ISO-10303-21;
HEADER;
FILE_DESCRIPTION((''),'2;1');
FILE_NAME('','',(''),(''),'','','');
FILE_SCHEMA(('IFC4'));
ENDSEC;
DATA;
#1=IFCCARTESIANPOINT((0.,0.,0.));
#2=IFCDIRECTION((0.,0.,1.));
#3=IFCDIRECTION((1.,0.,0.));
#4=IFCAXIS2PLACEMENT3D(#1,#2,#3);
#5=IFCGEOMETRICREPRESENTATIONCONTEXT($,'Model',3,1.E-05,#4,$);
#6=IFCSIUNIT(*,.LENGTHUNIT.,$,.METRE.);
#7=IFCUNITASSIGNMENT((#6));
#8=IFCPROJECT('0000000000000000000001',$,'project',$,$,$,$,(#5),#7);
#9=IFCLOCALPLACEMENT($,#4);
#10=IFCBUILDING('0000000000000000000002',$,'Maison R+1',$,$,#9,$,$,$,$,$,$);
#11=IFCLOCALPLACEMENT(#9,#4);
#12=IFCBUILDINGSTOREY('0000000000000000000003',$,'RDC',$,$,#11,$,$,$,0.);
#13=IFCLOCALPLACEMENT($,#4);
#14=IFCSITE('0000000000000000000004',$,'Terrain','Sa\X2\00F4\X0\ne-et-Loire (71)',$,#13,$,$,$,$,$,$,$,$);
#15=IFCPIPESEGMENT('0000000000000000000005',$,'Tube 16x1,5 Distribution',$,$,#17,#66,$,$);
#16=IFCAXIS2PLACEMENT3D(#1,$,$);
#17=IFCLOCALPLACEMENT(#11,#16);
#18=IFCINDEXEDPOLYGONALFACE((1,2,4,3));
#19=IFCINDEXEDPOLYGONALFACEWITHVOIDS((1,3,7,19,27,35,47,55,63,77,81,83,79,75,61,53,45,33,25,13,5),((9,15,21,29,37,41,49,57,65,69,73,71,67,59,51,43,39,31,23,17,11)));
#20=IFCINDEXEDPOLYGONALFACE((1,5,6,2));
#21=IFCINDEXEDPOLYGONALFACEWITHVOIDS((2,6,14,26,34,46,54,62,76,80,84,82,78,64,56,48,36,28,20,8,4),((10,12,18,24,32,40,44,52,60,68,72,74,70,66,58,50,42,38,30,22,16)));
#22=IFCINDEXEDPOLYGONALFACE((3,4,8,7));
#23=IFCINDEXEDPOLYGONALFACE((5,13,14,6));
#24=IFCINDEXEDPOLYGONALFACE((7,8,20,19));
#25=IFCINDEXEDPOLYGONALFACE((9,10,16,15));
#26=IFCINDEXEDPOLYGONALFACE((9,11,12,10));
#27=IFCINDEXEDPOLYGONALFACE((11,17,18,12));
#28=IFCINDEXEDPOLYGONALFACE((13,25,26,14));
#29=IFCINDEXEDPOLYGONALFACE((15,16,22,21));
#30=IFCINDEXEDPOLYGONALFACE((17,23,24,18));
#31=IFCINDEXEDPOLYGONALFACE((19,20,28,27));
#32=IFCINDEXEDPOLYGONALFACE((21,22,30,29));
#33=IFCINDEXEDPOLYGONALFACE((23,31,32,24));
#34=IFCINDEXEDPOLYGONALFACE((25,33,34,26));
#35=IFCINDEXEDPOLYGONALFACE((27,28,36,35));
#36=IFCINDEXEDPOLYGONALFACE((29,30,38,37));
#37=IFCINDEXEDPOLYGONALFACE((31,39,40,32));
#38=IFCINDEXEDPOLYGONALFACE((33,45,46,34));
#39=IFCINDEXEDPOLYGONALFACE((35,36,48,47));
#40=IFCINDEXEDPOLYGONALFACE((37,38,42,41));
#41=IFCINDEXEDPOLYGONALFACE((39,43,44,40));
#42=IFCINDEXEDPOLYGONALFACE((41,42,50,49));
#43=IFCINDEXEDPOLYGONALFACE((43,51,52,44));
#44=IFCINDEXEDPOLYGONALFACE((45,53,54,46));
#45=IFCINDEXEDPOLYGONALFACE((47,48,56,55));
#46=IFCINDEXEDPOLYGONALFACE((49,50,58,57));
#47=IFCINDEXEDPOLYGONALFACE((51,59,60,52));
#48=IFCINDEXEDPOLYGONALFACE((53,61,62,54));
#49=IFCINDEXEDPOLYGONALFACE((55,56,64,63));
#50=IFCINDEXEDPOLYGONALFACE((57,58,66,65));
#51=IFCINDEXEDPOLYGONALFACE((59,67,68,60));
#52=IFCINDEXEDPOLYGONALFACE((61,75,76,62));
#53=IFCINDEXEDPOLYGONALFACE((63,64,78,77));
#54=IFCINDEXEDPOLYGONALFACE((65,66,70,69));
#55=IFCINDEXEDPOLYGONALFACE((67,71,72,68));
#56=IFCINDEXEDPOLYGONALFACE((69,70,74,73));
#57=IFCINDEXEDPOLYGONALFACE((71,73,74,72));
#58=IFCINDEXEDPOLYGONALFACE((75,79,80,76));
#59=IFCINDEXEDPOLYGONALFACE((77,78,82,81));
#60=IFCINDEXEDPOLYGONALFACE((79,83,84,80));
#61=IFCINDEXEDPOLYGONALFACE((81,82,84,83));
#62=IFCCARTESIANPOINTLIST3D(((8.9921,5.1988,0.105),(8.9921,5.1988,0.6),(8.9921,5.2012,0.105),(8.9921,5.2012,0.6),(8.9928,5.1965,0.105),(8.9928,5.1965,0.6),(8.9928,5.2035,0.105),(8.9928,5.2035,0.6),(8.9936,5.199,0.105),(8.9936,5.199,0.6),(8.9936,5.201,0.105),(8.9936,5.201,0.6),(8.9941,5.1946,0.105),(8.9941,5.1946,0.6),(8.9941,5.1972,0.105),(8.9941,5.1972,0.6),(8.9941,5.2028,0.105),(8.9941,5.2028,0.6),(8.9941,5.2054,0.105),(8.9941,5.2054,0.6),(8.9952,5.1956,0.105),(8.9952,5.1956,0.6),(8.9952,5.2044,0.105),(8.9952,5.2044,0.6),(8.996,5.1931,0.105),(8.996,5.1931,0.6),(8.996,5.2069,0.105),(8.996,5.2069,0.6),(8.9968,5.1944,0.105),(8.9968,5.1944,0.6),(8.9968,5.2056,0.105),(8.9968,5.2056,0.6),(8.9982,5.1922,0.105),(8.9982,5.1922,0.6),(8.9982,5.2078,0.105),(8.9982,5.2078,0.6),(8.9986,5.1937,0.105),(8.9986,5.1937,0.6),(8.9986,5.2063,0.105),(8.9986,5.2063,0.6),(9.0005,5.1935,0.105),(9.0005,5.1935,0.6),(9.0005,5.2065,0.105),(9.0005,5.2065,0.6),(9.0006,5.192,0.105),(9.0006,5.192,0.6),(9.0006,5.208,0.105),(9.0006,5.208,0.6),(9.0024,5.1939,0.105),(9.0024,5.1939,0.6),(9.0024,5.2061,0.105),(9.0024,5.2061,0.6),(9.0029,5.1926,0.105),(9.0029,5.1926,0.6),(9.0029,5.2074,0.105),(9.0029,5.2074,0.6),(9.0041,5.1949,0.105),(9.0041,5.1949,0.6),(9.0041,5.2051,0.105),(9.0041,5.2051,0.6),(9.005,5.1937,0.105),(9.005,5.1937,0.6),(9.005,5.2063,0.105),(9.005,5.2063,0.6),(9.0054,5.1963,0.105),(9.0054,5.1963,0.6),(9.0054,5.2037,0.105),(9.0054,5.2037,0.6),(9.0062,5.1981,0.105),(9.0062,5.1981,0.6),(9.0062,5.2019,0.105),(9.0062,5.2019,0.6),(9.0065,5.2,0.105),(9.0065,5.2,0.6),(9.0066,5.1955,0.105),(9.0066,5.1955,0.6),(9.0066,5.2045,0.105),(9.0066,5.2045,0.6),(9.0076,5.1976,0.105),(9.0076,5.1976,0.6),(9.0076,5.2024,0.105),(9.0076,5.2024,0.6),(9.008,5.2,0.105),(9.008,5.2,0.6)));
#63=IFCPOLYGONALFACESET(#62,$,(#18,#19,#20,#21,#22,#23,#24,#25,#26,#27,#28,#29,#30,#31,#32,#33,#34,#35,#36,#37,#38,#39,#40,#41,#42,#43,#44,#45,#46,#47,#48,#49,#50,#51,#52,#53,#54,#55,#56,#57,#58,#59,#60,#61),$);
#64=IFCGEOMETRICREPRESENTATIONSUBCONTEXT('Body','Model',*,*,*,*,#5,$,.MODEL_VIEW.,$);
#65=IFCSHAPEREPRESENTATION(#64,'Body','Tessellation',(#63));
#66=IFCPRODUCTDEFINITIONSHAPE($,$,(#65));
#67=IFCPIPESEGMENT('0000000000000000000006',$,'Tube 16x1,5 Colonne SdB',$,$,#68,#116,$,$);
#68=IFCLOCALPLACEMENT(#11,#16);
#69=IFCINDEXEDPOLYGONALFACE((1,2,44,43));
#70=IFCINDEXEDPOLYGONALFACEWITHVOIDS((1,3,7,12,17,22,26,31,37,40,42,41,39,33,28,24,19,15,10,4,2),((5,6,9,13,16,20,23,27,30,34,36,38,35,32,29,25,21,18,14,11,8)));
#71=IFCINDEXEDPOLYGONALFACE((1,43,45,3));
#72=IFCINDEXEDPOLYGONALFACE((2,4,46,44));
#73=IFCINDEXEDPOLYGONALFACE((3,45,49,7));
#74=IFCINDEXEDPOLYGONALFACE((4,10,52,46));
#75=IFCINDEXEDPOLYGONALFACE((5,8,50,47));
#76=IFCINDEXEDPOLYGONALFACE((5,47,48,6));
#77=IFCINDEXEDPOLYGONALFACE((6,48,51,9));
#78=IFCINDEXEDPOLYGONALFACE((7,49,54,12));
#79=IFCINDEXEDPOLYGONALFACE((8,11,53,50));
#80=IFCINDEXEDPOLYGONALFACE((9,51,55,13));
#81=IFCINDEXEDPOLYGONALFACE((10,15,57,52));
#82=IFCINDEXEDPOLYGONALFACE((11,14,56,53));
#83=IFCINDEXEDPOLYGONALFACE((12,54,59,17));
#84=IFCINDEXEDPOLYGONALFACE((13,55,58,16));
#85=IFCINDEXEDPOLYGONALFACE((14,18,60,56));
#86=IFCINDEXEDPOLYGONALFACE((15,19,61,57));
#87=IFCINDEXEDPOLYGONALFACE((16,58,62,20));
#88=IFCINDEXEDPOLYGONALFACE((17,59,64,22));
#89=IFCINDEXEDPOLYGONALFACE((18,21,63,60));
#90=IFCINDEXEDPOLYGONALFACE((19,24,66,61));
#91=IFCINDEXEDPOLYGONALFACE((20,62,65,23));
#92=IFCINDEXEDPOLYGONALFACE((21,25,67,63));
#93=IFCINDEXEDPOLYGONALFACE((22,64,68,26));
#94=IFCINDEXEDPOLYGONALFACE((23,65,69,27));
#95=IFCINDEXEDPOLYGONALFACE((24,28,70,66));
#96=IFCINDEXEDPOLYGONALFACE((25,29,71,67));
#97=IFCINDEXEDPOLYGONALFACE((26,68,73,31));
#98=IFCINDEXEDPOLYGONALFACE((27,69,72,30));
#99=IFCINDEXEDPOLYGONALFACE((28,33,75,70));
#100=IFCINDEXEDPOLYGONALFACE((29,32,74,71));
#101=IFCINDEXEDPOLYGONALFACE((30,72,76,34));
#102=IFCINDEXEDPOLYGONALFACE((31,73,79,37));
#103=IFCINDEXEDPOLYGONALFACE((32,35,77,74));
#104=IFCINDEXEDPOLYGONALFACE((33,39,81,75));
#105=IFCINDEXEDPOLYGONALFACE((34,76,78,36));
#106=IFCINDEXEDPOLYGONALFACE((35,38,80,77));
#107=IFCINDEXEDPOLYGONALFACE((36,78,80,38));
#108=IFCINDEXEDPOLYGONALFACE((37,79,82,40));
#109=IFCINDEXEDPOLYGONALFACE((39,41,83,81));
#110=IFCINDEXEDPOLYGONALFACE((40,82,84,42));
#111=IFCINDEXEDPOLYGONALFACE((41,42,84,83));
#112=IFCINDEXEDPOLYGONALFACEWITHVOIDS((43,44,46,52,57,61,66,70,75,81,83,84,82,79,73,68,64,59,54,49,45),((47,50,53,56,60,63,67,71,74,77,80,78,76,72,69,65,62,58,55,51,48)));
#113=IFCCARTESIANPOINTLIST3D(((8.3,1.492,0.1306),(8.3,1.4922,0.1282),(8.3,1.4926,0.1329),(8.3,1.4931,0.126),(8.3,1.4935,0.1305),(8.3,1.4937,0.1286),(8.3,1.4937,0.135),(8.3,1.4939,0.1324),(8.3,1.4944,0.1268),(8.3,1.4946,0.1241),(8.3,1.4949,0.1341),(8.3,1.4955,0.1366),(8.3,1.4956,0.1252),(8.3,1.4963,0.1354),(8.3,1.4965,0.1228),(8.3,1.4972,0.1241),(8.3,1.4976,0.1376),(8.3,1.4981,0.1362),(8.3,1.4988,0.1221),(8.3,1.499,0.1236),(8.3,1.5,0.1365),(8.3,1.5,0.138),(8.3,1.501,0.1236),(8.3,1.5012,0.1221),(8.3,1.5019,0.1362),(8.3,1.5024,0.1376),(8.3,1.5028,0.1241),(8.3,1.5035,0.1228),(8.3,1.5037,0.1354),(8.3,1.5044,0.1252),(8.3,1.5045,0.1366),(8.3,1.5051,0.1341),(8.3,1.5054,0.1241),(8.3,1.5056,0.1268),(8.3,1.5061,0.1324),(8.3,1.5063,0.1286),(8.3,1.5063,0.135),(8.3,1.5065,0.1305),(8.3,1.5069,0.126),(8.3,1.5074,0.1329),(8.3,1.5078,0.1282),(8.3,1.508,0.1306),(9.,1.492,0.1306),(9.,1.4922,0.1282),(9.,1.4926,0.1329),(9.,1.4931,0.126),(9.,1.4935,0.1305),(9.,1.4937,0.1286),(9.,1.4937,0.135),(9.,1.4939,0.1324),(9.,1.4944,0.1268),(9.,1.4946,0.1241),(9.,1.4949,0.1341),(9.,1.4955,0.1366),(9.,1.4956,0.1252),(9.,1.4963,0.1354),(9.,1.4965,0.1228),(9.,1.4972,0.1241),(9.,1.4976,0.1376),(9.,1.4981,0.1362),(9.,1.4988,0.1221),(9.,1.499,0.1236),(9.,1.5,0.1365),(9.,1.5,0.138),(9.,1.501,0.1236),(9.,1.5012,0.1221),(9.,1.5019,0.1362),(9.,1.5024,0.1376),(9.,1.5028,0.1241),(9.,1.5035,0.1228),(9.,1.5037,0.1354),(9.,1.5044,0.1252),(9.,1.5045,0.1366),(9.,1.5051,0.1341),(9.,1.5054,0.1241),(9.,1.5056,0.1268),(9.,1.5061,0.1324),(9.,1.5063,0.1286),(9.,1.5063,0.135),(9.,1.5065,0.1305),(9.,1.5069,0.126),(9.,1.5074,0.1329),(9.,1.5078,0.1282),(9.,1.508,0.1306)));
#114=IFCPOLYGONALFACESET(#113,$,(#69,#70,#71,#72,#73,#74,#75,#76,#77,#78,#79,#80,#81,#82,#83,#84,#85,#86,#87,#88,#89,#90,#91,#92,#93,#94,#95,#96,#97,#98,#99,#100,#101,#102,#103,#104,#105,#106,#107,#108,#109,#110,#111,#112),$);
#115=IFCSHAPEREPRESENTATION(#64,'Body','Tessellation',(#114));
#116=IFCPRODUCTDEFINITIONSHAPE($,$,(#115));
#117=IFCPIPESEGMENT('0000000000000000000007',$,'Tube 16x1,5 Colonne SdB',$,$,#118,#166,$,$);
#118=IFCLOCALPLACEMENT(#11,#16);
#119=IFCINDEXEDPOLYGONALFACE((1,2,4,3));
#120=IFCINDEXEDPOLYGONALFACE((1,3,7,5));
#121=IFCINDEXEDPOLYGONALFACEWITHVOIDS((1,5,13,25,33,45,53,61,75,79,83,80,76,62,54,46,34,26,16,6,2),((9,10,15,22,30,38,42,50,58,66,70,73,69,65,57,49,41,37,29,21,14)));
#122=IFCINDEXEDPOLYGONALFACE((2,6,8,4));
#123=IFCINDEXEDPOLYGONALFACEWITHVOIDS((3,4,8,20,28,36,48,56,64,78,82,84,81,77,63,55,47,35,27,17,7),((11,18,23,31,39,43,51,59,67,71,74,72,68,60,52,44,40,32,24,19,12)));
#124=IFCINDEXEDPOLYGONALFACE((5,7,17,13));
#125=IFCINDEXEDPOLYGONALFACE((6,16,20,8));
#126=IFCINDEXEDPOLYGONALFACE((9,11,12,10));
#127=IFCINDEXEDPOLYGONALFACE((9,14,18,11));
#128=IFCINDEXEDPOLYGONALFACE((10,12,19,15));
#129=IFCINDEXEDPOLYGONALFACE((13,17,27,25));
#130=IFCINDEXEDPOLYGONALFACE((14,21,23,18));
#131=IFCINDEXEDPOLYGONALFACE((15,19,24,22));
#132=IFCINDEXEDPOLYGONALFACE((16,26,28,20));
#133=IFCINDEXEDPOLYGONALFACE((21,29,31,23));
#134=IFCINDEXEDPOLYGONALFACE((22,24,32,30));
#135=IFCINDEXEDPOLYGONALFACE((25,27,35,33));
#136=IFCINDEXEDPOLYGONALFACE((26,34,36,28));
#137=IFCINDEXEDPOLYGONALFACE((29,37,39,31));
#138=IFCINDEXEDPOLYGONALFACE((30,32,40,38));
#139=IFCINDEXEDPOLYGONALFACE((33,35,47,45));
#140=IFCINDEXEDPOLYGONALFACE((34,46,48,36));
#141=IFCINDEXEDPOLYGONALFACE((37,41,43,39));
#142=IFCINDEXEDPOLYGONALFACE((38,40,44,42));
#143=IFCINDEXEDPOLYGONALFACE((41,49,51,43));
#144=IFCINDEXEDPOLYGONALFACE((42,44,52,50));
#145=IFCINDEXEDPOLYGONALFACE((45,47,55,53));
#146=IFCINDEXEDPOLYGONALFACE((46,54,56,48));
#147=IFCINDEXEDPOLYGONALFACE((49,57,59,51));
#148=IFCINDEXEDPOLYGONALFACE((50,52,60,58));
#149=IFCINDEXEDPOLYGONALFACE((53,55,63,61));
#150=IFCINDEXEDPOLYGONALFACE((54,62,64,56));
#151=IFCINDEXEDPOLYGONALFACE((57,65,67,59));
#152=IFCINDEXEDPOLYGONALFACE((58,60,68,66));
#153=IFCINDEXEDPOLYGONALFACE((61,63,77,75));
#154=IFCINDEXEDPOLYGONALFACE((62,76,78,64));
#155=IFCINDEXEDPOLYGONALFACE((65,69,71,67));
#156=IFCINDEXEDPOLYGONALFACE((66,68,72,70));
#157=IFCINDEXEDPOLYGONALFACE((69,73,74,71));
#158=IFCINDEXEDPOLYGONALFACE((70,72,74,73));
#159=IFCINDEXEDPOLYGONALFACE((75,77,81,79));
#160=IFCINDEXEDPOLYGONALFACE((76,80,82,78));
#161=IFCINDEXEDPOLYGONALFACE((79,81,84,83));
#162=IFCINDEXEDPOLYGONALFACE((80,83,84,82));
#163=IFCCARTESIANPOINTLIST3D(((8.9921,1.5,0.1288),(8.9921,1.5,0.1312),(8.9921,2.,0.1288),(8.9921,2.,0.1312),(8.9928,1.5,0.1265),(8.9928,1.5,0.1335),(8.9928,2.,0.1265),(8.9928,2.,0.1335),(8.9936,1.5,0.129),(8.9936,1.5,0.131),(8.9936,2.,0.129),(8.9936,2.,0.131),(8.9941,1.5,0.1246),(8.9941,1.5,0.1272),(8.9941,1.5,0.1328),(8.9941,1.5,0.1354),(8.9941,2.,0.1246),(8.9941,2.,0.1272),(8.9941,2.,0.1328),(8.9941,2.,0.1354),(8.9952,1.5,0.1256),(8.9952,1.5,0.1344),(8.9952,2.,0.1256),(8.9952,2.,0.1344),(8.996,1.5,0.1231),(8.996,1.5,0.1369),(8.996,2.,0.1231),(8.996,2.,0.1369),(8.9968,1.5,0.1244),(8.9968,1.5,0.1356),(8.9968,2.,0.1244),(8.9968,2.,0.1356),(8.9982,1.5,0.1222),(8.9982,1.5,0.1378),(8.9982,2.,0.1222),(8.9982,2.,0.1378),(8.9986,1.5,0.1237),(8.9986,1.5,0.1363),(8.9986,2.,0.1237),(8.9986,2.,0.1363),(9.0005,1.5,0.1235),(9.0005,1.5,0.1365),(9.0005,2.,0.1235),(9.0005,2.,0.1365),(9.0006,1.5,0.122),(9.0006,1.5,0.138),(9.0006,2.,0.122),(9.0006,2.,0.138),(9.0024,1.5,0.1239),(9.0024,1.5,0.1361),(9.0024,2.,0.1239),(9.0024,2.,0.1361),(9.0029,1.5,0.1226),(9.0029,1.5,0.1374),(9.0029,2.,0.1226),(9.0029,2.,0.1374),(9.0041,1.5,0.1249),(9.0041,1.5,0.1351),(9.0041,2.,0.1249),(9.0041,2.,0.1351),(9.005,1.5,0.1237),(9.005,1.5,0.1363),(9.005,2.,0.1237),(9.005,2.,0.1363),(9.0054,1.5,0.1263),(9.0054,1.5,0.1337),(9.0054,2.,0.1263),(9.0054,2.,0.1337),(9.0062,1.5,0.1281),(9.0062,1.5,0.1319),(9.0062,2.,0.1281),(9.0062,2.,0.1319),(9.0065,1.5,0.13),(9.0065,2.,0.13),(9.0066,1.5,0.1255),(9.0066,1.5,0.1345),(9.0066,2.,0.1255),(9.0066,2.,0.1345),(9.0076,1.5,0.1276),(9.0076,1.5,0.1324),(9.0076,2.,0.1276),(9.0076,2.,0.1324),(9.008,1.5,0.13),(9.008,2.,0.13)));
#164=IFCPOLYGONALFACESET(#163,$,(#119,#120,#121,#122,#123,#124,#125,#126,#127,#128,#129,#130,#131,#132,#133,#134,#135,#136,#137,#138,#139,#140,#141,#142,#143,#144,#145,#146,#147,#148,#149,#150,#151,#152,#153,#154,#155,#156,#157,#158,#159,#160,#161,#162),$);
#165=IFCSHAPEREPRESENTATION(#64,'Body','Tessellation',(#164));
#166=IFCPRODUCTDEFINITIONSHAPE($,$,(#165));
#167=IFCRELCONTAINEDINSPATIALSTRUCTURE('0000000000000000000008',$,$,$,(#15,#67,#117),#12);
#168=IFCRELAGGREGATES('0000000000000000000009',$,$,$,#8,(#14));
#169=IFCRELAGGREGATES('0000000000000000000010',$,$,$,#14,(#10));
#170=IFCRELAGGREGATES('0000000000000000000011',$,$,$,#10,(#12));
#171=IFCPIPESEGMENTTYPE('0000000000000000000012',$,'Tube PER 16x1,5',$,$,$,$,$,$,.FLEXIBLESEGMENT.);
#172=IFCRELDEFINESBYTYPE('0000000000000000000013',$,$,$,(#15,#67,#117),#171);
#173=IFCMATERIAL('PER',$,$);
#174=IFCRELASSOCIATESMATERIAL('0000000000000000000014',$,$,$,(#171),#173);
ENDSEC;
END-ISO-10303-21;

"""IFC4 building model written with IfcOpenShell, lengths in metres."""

from ifc_helpers import new_model, si_unit, frame, origin_with_axes, place, context, subcontext, project, spatial, hollow_circle, extrude, material, type_object, element, save


model = new_model("IFC4")

# Units and contexts
model_context = context("Model", 3, precision=1e-05, world=origin_with_axes())
body_context = subcontext(model_context, "Body", "Model", "MODEL_VIEW")
ifc_project = project(units=[si_unit("LENGTHUNIT", "METRE")], contexts=[model_context])

# Site, building, storey
site_placement = place(None, origin_with_axes())
site = spatial("IfcSite", under=ifc_project, at=site_placement, Name="Terrain", Description="Saône-et-Loire (71)")
building_placement = place(None, origin_with_axes())
building = spatial("IfcBuilding", under=site, at=building_placement, Name="Maison R+1")
storey_placement = place(building_placement, origin_with_axes())
storey = spatial("IfcBuildingStorey", under=building, at=storey_placement, Name="RDC", Elevation=0.0)

# Pipe segments
ifc_material_1 = material(Name="PER")
pipe_segment_type_1 = type_object("IfcPipeSegmentType", Name="Tube PER 16x1,5", PredefinedType="FLEXIBLESEGMENT", material=ifc_material_1)
pipe_segment_1_placement = place(storey_placement, frame((9.0, 5.2, 0.105), z_axis=(0.0, 0.0, 1.0), x_axis=(1.0, 0.0, 0.0)))
element("IfcPipeSegment", 1, at=pipe_segment_1_placement, inside=storey, type_object=pipe_segment_type_1, Name="Tube 16x1,5 Distribution", context=body_context, shape_type="SweptSolid", body=[
    extrude(hollow_circle(Radius=0.008, WallThickness=0.0015), origin_with_axes(), (0.0, 0.0, 1.0), 0.495),
])
pipe_segment_2_placement = place(storey_placement, frame((8.3, 1.5, 0.13), z_axis=(1.0, 0.0, 0.0), x_axis=(0.0, 0.0, 1.0)))
element("IfcPipeSegment", 2, at=pipe_segment_2_placement, inside=storey, type_object=pipe_segment_type_1, Name="Tube 16x1,5 Colonne SdB", context=body_context, shape_type="SweptSolid", body=[
    extrude(hollow_circle(Radius=0.008, WallThickness=0.0015), origin_with_axes(), (0.0, 0.0, 1.0), 0.7),
])
pipe_segment_3_placement = place(storey_placement, frame((9.0, 1.5, 0.13), z_axis=(0.0, 1.0, 0.0), x_axis=(1.0, 0.0, 0.0)))
element("IfcPipeSegment", 3, at=pipe_segment_3_placement, inside=storey, type_object=pipe_segment_type_1, Name="Tube 16x1,5 Colonne SdB", context=body_context, shape_type="SweptSolid", body=[
    extrude(hollow_circle(Radius=0.008, WallThickness=0.0015), origin_with_axes(), (0.0, 0.0, 1.0), 0.5),
])

save(model, "model.ifc")
